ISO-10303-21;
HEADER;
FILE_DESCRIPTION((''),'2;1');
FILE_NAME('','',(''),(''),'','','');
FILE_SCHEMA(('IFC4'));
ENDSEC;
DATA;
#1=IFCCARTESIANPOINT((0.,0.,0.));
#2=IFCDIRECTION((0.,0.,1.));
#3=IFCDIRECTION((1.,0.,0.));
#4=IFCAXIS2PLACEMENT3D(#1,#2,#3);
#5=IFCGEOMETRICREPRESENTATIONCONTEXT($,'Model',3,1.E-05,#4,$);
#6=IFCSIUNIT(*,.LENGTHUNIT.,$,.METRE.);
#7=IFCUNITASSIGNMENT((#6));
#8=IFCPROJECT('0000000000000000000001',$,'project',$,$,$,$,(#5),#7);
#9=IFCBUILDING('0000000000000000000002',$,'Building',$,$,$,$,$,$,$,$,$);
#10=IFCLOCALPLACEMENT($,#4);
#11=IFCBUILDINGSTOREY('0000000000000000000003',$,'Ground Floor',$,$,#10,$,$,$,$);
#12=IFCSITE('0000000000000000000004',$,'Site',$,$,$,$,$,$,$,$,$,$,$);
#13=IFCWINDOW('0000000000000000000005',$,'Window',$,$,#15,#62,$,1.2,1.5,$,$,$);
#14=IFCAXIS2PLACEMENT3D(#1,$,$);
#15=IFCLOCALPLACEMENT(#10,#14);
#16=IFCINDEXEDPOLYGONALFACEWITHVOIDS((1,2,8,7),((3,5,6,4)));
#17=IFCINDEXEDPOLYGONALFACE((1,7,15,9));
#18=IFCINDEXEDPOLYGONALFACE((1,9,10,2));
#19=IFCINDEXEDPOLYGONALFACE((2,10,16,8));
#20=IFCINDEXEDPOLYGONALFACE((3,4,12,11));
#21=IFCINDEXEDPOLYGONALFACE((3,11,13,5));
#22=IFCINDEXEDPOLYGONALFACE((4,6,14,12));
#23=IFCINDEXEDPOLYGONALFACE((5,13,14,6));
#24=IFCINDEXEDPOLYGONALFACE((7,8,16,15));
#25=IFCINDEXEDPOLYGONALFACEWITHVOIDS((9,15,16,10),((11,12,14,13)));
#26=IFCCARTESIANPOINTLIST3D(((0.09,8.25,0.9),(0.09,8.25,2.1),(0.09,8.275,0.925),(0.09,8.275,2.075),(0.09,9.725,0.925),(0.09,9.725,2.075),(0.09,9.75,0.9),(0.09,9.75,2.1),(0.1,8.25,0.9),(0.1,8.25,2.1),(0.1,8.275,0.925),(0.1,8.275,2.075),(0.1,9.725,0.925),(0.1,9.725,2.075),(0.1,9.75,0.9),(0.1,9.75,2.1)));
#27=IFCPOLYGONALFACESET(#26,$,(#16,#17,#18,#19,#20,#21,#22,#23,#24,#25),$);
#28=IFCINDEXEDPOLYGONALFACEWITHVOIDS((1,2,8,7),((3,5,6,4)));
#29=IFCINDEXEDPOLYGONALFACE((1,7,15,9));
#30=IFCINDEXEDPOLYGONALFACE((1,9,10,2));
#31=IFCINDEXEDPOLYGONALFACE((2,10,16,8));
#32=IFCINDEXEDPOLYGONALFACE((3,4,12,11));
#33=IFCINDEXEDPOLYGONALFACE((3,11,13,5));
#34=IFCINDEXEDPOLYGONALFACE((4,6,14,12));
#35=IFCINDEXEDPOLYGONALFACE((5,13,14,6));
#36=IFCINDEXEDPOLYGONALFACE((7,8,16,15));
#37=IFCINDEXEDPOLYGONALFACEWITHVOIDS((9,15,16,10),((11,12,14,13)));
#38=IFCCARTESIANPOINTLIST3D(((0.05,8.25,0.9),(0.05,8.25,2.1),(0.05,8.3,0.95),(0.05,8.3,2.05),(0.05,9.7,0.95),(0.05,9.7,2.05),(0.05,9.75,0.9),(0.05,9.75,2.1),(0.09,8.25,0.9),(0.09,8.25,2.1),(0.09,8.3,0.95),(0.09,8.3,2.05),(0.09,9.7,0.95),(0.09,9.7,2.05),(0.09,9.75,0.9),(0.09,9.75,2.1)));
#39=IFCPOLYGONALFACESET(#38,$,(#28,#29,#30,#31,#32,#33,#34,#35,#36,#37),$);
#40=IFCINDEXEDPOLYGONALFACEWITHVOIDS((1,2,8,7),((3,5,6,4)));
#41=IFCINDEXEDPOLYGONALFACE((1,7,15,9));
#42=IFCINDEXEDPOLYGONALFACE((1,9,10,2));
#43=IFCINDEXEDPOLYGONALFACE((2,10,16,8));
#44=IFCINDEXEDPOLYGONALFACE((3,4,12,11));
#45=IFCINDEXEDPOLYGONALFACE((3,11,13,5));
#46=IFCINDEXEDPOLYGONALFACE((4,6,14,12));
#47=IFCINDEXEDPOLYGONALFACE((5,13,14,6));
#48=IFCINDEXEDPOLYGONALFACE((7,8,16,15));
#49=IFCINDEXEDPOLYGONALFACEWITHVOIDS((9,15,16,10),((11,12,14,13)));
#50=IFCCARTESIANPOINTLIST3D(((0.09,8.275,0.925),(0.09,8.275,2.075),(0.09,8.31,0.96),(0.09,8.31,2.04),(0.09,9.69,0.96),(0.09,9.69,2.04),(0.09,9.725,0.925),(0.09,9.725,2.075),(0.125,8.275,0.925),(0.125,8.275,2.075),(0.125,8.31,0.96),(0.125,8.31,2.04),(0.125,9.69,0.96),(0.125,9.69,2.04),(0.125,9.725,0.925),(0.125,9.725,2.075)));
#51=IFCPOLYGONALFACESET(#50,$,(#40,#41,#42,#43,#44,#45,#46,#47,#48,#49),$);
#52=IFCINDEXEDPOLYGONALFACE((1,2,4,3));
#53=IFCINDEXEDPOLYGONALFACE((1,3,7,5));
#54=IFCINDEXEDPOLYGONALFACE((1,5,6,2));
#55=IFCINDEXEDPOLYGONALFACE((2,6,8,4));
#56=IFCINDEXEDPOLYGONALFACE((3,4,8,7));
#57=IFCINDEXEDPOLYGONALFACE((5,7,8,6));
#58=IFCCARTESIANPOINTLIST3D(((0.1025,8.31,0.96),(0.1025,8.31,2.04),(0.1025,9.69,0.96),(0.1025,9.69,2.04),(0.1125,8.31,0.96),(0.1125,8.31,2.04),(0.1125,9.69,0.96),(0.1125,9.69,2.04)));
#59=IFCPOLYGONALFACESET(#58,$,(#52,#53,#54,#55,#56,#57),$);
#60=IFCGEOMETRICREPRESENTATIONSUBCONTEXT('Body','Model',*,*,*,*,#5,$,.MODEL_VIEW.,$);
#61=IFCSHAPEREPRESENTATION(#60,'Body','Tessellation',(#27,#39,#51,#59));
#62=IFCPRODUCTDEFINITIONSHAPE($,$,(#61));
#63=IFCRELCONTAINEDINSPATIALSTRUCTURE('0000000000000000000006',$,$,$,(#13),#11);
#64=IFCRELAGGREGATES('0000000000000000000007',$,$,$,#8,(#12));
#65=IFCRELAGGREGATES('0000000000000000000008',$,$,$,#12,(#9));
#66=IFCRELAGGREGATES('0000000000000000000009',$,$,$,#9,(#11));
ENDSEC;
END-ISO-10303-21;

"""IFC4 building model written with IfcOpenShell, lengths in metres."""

from ifc_helpers import new_model, si_unit, frame, origin_with_axes, place, context, subcontext, project, spatial, line, indexed_curve, outline, extrude, element, save


model = new_model("IFC4")

# Units and contexts
model_context = context("Model", 3, precision=1e-05, world=origin_with_axes())
body_context = subcontext(model_context, "Body", "Model", "MODEL_VIEW")
ifc_project = project(units=[si_unit("LENGTHUNIT", "METRE")], contexts=[model_context])

# Site, building, storey
site = spatial("IfcSite", under=ifc_project, Name="Site")
building = spatial("IfcBuilding", under=site, Name="Building")
storey_placement = place(None, origin_with_axes())
storey = spatial("IfcBuildingStorey", under=building, at=storey_placement, Name="Ground Floor")

# Window
for number, where, z_axis, x_axis, name in (
    (1, (0.0, 9.75, 0.9), (0.0, 0.0, 1.0), (0.0, -1.0, 0.0), "Window"),
):
    element("IfcWindow", number, at=place(storey_placement, frame(where, z_axis=z_axis, x_axis=x_axis)), inside=storey, Name=name, OverallHeight=1.2, OverallWidth=1.5, context=body_context, shape_type="SweptSolid", body=[
        extrude(outline(indexed_curve([(0.0, 0.0), (1.5, 0.0), (1.5, 1.2), (0.0, 1.2)], segments=[line(1, 2, 3, 4, 1)]), holes=[indexed_curve([(0.025, 0.025), (1.475, 0.025), (1.475, 1.175), (0.025, 1.175)], segments=[line(1, 2, 3, 4, 1)])]), frame((0.0, 0.09, 0.0), z_axis=(0.0, -1.0, 0.0), x_axis=(1.0, 0.0, 0.0)), (0.0, 0.0, -1.0), 0.01),
        extrude(outline(indexed_curve([(0.0, 0.0), (1.5, 0.0), (1.5, 1.2), (0.0, 1.2)], segments=[line(1, 2, 3, 4, 1)]), holes=[indexed_curve([(0.05, 0.05), (1.45, 0.05), (1.45, 1.15), (0.05, 1.15)], segments=[line(1, 2, 3, 4, 1)])]), frame((0.0, 0.05, 0.0), z_axis=(0.0, -1.0, 0.0), x_axis=(1.0, 0.0, 0.0)), (0.0, 0.0, -1.0), 0.04),
        extrude(outline(indexed_curve([(0.0, 0.0), (1.45, 0.0), (1.45, 1.15), (0.0, 1.15)], segments=[line(1, 2, 3, 4, 1)]), holes=[indexed_curve([(0.035, 0.035), (1.415, 0.035), (1.415, 1.115), (0.035, 1.115)], segments=[line(1, 2, 3, 4, 1)])]), frame((0.025, 0.09, 0.025), z_axis=(0.0, -1.0, 0.0), x_axis=(1.0, 0.0, 0.0)), (0.0, 0.0, -1.0), 0.035),
        extrude(outline(indexed_curve([(0.035, 0.035), (1.415, 0.035), (1.415, 1.115), (0.035, 1.115)], segments=[line(1, 2, 3, 4, 1)])), frame((0.025, 0.1025, 0.025), z_axis=(0.0, -1.0, 0.0), x_axis=(1.0, 0.0, 0.0)), (0.0, 0.0, -1.0), 0.01),
    ])

save(model, "model.ifc")
